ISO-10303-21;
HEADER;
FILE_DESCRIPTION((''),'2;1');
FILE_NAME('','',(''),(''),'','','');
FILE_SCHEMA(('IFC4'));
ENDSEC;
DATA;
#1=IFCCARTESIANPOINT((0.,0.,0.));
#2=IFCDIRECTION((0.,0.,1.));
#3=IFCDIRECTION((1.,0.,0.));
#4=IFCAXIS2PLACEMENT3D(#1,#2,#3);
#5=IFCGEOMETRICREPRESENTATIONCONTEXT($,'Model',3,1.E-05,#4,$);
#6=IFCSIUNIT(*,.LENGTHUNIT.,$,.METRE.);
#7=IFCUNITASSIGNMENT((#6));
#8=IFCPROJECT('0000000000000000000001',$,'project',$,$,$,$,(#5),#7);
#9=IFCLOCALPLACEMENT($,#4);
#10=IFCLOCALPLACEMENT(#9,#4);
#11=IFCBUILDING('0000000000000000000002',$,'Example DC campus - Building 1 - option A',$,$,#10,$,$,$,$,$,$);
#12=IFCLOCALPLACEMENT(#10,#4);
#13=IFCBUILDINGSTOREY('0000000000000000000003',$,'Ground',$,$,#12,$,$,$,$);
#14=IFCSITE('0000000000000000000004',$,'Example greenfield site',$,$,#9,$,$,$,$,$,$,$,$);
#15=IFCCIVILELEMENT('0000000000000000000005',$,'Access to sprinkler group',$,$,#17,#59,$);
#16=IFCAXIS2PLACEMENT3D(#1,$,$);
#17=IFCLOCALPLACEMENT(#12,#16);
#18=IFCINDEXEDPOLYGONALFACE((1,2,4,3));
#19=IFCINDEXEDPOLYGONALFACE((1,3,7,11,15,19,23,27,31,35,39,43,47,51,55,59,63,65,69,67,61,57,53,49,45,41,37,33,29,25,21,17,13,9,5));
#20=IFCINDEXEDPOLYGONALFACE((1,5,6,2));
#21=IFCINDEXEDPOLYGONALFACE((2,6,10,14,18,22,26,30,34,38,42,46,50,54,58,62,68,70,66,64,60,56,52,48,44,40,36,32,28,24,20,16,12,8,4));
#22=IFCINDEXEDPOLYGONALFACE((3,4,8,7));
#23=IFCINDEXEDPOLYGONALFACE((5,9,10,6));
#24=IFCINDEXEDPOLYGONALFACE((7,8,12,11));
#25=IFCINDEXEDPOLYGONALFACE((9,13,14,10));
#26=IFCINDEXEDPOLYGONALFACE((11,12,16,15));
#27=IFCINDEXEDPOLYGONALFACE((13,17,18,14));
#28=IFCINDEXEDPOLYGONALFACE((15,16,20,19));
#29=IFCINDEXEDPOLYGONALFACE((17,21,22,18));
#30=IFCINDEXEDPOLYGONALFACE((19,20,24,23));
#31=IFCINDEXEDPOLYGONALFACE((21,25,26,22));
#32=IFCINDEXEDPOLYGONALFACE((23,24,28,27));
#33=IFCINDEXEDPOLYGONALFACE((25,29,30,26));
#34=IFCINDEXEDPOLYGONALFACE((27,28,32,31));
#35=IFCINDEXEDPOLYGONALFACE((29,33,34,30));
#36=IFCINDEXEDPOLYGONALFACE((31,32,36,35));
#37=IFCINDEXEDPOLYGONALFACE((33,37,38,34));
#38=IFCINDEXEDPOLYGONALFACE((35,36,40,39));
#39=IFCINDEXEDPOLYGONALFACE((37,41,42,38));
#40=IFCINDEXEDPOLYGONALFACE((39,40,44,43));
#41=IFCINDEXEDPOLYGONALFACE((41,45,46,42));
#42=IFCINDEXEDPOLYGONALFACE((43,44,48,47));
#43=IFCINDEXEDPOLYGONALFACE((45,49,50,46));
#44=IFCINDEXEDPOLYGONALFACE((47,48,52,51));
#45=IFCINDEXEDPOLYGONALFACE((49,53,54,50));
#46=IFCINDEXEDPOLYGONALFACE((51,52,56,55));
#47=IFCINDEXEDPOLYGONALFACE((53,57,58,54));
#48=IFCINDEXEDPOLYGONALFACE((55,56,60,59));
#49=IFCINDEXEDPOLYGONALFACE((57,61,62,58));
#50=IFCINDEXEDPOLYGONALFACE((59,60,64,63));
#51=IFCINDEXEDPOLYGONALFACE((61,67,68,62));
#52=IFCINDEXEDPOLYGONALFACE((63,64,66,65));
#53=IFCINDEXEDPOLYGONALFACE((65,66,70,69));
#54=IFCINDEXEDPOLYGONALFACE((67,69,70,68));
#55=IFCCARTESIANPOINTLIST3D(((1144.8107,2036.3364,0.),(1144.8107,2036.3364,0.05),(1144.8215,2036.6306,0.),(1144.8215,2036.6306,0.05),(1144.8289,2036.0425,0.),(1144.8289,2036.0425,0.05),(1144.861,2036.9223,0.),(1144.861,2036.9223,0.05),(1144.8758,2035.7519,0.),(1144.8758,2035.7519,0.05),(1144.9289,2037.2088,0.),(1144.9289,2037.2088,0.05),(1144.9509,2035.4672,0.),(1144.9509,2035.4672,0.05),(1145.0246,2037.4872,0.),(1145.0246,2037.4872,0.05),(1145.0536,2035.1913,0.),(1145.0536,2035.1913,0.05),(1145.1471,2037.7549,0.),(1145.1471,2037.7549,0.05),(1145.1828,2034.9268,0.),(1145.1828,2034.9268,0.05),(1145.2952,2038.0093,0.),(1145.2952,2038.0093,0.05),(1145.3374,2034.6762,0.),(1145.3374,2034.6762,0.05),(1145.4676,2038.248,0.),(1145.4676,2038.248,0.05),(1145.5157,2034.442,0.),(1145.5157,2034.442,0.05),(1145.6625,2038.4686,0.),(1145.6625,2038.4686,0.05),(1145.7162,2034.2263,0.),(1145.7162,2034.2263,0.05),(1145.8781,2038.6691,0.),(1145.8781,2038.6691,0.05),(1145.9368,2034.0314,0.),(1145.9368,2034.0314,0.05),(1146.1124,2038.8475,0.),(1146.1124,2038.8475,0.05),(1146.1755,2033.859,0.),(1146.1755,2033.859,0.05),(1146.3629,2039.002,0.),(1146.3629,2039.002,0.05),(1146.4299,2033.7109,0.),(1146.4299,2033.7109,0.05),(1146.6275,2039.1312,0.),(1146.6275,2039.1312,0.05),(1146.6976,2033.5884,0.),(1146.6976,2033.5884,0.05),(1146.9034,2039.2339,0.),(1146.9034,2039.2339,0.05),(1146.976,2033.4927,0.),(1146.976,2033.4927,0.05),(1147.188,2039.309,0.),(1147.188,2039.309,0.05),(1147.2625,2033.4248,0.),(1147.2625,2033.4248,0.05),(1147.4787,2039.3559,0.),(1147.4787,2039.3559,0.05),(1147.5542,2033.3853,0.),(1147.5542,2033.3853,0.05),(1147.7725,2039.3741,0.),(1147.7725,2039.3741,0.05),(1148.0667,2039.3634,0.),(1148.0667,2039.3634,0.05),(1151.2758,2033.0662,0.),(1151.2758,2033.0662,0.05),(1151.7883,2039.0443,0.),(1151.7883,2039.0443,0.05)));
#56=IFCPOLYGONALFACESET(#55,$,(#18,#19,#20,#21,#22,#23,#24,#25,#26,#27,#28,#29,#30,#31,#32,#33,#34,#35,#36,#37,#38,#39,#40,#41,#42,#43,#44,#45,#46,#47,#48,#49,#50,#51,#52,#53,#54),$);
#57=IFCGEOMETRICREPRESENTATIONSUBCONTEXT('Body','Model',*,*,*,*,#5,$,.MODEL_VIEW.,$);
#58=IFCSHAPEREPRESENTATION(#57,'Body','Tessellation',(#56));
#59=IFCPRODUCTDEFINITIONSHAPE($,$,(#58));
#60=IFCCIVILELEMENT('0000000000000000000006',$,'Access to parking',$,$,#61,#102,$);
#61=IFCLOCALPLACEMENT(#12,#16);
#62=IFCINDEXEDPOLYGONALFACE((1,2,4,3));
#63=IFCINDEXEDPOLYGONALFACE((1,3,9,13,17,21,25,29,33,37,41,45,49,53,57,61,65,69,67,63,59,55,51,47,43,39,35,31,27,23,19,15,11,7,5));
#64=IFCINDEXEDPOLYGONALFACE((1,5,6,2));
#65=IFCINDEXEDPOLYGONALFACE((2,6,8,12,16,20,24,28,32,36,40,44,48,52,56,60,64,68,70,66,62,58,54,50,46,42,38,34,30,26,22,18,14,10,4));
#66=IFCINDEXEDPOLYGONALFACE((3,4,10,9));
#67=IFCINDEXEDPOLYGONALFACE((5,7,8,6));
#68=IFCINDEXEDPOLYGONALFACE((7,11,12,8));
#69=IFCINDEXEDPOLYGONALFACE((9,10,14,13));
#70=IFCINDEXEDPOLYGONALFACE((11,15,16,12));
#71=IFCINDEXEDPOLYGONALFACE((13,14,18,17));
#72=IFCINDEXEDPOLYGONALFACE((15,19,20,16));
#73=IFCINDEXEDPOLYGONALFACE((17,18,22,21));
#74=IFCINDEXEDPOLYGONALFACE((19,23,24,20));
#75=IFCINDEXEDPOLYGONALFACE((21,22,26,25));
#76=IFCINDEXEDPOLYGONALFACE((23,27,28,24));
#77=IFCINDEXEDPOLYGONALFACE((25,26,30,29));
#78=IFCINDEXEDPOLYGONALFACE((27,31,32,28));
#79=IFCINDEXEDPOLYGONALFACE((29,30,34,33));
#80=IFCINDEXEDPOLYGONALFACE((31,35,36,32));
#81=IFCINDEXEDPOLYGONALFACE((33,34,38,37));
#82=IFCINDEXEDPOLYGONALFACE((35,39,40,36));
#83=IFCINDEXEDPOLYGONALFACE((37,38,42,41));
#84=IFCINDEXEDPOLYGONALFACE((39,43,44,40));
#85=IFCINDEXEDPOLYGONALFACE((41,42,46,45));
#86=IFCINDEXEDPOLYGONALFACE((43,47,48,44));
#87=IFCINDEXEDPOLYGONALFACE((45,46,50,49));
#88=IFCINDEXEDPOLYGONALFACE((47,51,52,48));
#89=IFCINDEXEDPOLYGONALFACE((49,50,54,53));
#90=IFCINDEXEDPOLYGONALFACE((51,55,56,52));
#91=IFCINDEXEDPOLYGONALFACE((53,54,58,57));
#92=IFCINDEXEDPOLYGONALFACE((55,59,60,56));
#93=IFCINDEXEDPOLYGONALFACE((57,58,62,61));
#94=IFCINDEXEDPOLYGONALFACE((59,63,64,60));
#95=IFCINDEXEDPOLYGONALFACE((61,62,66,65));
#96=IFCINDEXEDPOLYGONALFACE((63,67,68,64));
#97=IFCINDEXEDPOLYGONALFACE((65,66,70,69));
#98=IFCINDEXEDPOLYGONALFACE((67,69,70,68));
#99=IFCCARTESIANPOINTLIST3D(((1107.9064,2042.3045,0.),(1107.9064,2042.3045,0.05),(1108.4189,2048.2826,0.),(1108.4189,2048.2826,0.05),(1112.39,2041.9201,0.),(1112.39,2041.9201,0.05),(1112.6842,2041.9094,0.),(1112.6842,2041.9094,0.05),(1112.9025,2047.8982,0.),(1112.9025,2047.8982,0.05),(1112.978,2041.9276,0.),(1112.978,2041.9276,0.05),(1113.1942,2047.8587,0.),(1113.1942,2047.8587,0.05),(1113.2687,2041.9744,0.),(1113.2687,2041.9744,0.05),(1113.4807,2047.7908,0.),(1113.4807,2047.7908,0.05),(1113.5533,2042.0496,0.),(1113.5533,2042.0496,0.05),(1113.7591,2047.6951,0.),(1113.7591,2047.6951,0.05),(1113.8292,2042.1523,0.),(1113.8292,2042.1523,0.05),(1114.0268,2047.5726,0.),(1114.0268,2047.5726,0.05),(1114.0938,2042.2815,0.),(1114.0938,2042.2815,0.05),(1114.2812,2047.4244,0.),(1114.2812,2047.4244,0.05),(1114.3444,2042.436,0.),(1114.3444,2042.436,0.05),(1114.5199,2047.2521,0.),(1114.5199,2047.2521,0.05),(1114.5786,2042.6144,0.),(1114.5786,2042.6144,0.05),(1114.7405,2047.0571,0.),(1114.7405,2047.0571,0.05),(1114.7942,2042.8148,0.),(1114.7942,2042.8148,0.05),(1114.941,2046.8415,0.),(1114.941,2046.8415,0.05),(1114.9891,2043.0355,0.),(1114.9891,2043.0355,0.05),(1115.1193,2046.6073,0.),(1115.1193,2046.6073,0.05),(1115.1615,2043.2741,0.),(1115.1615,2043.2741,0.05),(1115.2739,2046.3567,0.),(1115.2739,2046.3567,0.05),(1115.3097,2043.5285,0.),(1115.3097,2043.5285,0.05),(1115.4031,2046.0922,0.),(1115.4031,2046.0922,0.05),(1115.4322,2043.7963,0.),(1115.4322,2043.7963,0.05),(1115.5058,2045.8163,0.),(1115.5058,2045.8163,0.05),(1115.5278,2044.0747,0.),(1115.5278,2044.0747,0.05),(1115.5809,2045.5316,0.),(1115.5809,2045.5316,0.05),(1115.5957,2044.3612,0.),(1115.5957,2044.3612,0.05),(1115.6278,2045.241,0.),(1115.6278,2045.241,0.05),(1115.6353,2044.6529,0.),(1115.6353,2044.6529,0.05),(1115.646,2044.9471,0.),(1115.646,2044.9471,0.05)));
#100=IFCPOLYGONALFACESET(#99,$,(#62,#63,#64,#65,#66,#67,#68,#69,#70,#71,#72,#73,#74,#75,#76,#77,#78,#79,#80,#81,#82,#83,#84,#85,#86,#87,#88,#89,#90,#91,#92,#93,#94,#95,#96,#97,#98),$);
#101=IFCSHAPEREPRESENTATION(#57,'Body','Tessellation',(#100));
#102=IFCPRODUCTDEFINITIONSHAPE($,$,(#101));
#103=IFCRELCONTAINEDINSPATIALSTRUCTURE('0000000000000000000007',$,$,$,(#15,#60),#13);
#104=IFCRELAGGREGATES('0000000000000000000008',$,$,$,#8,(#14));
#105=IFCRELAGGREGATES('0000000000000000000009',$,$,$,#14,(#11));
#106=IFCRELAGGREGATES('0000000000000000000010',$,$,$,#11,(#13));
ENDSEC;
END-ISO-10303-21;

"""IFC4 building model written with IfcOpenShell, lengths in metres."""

from ifc_helpers import new_model, si_unit, frame, origin_with_axes, place, context, subcontext, project, spatial, line, indexed_curve, outline, extrude, element, save


model = new_model("IFC4")

# Units and contexts
model_context = context("Model", 3, precision=1e-05, world=origin_with_axes())
body_context = subcontext(model_context, "Body", "Model", "MODEL_VIEW")
ifc_project = project(units=[si_unit("LENGTHUNIT", "METRE")], contexts=[model_context])

# Site, building, storey
site_placement = place(None, origin_with_axes())
site = spatial("IfcSite", under=ifc_project, at=site_placement, Name="Example greenfield site")
building_placement = place(site_placement, origin_with_axes())
building = spatial("IfcBuilding", under=site, at=building_placement, Name="Example DC campus - Building 1 - option A")
storey_placement = place(building_placement, origin_with_axes())
storey = spatial("IfcBuildingStorey", under=building, at=storey_placement, Name="Ground")

# Civil elements
civil_element_1_placement = place(storey_placement, frame((1144.5652, 2033.6415, 0.0), z_axis=(0.0, 0.0, 1.0), x_axis=(0.996345, -0.085417, 0.0)))
element("IfcCivilElement", 1, at=civil_element_1_placement, inside=storey, Name="Access to sprinkler group", context=body_context, shape_type="SweptSolid", body=[
    extrude(outline(indexed_curve([(6.7352, 0.0), (3.0, 0.0), (2.7059, 0.0144), (2.4147, 0.0576), (2.1291, 0.1292), (1.8519, 0.2284), (1.5858, 0.3542), (1.3333, 0.5056), (1.0968, 0.681), (0.8787, 0.8787), (0.681, 1.0968), (0.5056, 1.3333), (0.3542, 1.5858), (0.2284, 1.8519), (0.1292, 2.1291), (0.0576, 2.4147), (0.0144, 2.7059), (0.0, 3.0), (0.0144, 3.2941), (0.0576, 3.5853), (0.1292, 3.8709), (0.2284, 4.1481), (0.3542, 4.4142), (0.5056, 4.6667), (0.681, 4.9032), (0.8787, 5.1213), (1.0968, 5.319), (1.3333, 5.4944), (1.5858, 5.6458), (1.8519, 5.7716), (2.1291, 5.8708), (2.4147, 5.9424), (2.7059, 5.9856), (3.0, 6.0), (6.7352, 6.0)], segments=[line(1, 2, 3, 4, 5, 6, 7, 8, 9, 10, 11, 12, 13, 14, 15, 16, 17, 18, 19, 20, 21, 22, 23, 24, 25, 26, 27, 28, 29, 30, 31, 32, 33, 34, 35, 1)])), origin_with_axes(), (0.0, 0.0, 1.0), 0.05),
])
civil_element_2_placement = place(storey_placement, frame((1107.9064, 2042.3045, 0.0), z_axis=(0.0, 0.0, 1.0), x_axis=(0.996345, -0.085417, 0.0)))
element("IfcCivilElement", 2, at=civil_element_2_placement, inside=storey, Name="Access to parking", context=body_context, shape_type="SweptSolid", body=[
    extrude(outline(indexed_curve([(0.0, 6.0), (4.5, 6.0), (4.7941, 5.9856), (5.0853, 5.9424), (5.3709, 5.8708), (5.6481, 5.7716), (5.9142, 5.6458), (6.1667, 5.4944), (6.4032, 5.319), (6.6213, 5.1213), (6.819, 4.9032), (6.9944, 4.6667), (7.1458, 4.4142), (7.2716, 4.1481), (7.3708, 3.8709), (7.4424, 3.5853), (7.4856, 3.2941), (7.5, 3.0), (7.4856, 2.7059), (7.4424, 2.4147), (7.3708, 2.1291), (7.2716, 1.8519), (7.1458, 1.5858), (6.9944, 1.3333), (6.819, 1.0968), (6.6213, 0.8787), (6.4032, 0.681), (6.1667, 0.5056), (5.9142, 0.3542), (5.6481, 0.2284), (5.3709, 0.1292), (5.0853, 0.0576), (4.7941, 0.0144), (4.5, 0.0), (0.0, 0.0)], segments=[line(1, 2, 3, 4, 5, 6, 7, 8, 9, 10, 11, 12, 13, 14, 15, 16, 17, 18, 19, 20, 21, 22, 23, 24, 25, 26, 27, 28, 29, 30, 31, 32, 33, 34, 35, 1)])), origin_with_axes(), (0.0, 0.0, 1.0), 0.05),
])

save(model, "model.ifc")
